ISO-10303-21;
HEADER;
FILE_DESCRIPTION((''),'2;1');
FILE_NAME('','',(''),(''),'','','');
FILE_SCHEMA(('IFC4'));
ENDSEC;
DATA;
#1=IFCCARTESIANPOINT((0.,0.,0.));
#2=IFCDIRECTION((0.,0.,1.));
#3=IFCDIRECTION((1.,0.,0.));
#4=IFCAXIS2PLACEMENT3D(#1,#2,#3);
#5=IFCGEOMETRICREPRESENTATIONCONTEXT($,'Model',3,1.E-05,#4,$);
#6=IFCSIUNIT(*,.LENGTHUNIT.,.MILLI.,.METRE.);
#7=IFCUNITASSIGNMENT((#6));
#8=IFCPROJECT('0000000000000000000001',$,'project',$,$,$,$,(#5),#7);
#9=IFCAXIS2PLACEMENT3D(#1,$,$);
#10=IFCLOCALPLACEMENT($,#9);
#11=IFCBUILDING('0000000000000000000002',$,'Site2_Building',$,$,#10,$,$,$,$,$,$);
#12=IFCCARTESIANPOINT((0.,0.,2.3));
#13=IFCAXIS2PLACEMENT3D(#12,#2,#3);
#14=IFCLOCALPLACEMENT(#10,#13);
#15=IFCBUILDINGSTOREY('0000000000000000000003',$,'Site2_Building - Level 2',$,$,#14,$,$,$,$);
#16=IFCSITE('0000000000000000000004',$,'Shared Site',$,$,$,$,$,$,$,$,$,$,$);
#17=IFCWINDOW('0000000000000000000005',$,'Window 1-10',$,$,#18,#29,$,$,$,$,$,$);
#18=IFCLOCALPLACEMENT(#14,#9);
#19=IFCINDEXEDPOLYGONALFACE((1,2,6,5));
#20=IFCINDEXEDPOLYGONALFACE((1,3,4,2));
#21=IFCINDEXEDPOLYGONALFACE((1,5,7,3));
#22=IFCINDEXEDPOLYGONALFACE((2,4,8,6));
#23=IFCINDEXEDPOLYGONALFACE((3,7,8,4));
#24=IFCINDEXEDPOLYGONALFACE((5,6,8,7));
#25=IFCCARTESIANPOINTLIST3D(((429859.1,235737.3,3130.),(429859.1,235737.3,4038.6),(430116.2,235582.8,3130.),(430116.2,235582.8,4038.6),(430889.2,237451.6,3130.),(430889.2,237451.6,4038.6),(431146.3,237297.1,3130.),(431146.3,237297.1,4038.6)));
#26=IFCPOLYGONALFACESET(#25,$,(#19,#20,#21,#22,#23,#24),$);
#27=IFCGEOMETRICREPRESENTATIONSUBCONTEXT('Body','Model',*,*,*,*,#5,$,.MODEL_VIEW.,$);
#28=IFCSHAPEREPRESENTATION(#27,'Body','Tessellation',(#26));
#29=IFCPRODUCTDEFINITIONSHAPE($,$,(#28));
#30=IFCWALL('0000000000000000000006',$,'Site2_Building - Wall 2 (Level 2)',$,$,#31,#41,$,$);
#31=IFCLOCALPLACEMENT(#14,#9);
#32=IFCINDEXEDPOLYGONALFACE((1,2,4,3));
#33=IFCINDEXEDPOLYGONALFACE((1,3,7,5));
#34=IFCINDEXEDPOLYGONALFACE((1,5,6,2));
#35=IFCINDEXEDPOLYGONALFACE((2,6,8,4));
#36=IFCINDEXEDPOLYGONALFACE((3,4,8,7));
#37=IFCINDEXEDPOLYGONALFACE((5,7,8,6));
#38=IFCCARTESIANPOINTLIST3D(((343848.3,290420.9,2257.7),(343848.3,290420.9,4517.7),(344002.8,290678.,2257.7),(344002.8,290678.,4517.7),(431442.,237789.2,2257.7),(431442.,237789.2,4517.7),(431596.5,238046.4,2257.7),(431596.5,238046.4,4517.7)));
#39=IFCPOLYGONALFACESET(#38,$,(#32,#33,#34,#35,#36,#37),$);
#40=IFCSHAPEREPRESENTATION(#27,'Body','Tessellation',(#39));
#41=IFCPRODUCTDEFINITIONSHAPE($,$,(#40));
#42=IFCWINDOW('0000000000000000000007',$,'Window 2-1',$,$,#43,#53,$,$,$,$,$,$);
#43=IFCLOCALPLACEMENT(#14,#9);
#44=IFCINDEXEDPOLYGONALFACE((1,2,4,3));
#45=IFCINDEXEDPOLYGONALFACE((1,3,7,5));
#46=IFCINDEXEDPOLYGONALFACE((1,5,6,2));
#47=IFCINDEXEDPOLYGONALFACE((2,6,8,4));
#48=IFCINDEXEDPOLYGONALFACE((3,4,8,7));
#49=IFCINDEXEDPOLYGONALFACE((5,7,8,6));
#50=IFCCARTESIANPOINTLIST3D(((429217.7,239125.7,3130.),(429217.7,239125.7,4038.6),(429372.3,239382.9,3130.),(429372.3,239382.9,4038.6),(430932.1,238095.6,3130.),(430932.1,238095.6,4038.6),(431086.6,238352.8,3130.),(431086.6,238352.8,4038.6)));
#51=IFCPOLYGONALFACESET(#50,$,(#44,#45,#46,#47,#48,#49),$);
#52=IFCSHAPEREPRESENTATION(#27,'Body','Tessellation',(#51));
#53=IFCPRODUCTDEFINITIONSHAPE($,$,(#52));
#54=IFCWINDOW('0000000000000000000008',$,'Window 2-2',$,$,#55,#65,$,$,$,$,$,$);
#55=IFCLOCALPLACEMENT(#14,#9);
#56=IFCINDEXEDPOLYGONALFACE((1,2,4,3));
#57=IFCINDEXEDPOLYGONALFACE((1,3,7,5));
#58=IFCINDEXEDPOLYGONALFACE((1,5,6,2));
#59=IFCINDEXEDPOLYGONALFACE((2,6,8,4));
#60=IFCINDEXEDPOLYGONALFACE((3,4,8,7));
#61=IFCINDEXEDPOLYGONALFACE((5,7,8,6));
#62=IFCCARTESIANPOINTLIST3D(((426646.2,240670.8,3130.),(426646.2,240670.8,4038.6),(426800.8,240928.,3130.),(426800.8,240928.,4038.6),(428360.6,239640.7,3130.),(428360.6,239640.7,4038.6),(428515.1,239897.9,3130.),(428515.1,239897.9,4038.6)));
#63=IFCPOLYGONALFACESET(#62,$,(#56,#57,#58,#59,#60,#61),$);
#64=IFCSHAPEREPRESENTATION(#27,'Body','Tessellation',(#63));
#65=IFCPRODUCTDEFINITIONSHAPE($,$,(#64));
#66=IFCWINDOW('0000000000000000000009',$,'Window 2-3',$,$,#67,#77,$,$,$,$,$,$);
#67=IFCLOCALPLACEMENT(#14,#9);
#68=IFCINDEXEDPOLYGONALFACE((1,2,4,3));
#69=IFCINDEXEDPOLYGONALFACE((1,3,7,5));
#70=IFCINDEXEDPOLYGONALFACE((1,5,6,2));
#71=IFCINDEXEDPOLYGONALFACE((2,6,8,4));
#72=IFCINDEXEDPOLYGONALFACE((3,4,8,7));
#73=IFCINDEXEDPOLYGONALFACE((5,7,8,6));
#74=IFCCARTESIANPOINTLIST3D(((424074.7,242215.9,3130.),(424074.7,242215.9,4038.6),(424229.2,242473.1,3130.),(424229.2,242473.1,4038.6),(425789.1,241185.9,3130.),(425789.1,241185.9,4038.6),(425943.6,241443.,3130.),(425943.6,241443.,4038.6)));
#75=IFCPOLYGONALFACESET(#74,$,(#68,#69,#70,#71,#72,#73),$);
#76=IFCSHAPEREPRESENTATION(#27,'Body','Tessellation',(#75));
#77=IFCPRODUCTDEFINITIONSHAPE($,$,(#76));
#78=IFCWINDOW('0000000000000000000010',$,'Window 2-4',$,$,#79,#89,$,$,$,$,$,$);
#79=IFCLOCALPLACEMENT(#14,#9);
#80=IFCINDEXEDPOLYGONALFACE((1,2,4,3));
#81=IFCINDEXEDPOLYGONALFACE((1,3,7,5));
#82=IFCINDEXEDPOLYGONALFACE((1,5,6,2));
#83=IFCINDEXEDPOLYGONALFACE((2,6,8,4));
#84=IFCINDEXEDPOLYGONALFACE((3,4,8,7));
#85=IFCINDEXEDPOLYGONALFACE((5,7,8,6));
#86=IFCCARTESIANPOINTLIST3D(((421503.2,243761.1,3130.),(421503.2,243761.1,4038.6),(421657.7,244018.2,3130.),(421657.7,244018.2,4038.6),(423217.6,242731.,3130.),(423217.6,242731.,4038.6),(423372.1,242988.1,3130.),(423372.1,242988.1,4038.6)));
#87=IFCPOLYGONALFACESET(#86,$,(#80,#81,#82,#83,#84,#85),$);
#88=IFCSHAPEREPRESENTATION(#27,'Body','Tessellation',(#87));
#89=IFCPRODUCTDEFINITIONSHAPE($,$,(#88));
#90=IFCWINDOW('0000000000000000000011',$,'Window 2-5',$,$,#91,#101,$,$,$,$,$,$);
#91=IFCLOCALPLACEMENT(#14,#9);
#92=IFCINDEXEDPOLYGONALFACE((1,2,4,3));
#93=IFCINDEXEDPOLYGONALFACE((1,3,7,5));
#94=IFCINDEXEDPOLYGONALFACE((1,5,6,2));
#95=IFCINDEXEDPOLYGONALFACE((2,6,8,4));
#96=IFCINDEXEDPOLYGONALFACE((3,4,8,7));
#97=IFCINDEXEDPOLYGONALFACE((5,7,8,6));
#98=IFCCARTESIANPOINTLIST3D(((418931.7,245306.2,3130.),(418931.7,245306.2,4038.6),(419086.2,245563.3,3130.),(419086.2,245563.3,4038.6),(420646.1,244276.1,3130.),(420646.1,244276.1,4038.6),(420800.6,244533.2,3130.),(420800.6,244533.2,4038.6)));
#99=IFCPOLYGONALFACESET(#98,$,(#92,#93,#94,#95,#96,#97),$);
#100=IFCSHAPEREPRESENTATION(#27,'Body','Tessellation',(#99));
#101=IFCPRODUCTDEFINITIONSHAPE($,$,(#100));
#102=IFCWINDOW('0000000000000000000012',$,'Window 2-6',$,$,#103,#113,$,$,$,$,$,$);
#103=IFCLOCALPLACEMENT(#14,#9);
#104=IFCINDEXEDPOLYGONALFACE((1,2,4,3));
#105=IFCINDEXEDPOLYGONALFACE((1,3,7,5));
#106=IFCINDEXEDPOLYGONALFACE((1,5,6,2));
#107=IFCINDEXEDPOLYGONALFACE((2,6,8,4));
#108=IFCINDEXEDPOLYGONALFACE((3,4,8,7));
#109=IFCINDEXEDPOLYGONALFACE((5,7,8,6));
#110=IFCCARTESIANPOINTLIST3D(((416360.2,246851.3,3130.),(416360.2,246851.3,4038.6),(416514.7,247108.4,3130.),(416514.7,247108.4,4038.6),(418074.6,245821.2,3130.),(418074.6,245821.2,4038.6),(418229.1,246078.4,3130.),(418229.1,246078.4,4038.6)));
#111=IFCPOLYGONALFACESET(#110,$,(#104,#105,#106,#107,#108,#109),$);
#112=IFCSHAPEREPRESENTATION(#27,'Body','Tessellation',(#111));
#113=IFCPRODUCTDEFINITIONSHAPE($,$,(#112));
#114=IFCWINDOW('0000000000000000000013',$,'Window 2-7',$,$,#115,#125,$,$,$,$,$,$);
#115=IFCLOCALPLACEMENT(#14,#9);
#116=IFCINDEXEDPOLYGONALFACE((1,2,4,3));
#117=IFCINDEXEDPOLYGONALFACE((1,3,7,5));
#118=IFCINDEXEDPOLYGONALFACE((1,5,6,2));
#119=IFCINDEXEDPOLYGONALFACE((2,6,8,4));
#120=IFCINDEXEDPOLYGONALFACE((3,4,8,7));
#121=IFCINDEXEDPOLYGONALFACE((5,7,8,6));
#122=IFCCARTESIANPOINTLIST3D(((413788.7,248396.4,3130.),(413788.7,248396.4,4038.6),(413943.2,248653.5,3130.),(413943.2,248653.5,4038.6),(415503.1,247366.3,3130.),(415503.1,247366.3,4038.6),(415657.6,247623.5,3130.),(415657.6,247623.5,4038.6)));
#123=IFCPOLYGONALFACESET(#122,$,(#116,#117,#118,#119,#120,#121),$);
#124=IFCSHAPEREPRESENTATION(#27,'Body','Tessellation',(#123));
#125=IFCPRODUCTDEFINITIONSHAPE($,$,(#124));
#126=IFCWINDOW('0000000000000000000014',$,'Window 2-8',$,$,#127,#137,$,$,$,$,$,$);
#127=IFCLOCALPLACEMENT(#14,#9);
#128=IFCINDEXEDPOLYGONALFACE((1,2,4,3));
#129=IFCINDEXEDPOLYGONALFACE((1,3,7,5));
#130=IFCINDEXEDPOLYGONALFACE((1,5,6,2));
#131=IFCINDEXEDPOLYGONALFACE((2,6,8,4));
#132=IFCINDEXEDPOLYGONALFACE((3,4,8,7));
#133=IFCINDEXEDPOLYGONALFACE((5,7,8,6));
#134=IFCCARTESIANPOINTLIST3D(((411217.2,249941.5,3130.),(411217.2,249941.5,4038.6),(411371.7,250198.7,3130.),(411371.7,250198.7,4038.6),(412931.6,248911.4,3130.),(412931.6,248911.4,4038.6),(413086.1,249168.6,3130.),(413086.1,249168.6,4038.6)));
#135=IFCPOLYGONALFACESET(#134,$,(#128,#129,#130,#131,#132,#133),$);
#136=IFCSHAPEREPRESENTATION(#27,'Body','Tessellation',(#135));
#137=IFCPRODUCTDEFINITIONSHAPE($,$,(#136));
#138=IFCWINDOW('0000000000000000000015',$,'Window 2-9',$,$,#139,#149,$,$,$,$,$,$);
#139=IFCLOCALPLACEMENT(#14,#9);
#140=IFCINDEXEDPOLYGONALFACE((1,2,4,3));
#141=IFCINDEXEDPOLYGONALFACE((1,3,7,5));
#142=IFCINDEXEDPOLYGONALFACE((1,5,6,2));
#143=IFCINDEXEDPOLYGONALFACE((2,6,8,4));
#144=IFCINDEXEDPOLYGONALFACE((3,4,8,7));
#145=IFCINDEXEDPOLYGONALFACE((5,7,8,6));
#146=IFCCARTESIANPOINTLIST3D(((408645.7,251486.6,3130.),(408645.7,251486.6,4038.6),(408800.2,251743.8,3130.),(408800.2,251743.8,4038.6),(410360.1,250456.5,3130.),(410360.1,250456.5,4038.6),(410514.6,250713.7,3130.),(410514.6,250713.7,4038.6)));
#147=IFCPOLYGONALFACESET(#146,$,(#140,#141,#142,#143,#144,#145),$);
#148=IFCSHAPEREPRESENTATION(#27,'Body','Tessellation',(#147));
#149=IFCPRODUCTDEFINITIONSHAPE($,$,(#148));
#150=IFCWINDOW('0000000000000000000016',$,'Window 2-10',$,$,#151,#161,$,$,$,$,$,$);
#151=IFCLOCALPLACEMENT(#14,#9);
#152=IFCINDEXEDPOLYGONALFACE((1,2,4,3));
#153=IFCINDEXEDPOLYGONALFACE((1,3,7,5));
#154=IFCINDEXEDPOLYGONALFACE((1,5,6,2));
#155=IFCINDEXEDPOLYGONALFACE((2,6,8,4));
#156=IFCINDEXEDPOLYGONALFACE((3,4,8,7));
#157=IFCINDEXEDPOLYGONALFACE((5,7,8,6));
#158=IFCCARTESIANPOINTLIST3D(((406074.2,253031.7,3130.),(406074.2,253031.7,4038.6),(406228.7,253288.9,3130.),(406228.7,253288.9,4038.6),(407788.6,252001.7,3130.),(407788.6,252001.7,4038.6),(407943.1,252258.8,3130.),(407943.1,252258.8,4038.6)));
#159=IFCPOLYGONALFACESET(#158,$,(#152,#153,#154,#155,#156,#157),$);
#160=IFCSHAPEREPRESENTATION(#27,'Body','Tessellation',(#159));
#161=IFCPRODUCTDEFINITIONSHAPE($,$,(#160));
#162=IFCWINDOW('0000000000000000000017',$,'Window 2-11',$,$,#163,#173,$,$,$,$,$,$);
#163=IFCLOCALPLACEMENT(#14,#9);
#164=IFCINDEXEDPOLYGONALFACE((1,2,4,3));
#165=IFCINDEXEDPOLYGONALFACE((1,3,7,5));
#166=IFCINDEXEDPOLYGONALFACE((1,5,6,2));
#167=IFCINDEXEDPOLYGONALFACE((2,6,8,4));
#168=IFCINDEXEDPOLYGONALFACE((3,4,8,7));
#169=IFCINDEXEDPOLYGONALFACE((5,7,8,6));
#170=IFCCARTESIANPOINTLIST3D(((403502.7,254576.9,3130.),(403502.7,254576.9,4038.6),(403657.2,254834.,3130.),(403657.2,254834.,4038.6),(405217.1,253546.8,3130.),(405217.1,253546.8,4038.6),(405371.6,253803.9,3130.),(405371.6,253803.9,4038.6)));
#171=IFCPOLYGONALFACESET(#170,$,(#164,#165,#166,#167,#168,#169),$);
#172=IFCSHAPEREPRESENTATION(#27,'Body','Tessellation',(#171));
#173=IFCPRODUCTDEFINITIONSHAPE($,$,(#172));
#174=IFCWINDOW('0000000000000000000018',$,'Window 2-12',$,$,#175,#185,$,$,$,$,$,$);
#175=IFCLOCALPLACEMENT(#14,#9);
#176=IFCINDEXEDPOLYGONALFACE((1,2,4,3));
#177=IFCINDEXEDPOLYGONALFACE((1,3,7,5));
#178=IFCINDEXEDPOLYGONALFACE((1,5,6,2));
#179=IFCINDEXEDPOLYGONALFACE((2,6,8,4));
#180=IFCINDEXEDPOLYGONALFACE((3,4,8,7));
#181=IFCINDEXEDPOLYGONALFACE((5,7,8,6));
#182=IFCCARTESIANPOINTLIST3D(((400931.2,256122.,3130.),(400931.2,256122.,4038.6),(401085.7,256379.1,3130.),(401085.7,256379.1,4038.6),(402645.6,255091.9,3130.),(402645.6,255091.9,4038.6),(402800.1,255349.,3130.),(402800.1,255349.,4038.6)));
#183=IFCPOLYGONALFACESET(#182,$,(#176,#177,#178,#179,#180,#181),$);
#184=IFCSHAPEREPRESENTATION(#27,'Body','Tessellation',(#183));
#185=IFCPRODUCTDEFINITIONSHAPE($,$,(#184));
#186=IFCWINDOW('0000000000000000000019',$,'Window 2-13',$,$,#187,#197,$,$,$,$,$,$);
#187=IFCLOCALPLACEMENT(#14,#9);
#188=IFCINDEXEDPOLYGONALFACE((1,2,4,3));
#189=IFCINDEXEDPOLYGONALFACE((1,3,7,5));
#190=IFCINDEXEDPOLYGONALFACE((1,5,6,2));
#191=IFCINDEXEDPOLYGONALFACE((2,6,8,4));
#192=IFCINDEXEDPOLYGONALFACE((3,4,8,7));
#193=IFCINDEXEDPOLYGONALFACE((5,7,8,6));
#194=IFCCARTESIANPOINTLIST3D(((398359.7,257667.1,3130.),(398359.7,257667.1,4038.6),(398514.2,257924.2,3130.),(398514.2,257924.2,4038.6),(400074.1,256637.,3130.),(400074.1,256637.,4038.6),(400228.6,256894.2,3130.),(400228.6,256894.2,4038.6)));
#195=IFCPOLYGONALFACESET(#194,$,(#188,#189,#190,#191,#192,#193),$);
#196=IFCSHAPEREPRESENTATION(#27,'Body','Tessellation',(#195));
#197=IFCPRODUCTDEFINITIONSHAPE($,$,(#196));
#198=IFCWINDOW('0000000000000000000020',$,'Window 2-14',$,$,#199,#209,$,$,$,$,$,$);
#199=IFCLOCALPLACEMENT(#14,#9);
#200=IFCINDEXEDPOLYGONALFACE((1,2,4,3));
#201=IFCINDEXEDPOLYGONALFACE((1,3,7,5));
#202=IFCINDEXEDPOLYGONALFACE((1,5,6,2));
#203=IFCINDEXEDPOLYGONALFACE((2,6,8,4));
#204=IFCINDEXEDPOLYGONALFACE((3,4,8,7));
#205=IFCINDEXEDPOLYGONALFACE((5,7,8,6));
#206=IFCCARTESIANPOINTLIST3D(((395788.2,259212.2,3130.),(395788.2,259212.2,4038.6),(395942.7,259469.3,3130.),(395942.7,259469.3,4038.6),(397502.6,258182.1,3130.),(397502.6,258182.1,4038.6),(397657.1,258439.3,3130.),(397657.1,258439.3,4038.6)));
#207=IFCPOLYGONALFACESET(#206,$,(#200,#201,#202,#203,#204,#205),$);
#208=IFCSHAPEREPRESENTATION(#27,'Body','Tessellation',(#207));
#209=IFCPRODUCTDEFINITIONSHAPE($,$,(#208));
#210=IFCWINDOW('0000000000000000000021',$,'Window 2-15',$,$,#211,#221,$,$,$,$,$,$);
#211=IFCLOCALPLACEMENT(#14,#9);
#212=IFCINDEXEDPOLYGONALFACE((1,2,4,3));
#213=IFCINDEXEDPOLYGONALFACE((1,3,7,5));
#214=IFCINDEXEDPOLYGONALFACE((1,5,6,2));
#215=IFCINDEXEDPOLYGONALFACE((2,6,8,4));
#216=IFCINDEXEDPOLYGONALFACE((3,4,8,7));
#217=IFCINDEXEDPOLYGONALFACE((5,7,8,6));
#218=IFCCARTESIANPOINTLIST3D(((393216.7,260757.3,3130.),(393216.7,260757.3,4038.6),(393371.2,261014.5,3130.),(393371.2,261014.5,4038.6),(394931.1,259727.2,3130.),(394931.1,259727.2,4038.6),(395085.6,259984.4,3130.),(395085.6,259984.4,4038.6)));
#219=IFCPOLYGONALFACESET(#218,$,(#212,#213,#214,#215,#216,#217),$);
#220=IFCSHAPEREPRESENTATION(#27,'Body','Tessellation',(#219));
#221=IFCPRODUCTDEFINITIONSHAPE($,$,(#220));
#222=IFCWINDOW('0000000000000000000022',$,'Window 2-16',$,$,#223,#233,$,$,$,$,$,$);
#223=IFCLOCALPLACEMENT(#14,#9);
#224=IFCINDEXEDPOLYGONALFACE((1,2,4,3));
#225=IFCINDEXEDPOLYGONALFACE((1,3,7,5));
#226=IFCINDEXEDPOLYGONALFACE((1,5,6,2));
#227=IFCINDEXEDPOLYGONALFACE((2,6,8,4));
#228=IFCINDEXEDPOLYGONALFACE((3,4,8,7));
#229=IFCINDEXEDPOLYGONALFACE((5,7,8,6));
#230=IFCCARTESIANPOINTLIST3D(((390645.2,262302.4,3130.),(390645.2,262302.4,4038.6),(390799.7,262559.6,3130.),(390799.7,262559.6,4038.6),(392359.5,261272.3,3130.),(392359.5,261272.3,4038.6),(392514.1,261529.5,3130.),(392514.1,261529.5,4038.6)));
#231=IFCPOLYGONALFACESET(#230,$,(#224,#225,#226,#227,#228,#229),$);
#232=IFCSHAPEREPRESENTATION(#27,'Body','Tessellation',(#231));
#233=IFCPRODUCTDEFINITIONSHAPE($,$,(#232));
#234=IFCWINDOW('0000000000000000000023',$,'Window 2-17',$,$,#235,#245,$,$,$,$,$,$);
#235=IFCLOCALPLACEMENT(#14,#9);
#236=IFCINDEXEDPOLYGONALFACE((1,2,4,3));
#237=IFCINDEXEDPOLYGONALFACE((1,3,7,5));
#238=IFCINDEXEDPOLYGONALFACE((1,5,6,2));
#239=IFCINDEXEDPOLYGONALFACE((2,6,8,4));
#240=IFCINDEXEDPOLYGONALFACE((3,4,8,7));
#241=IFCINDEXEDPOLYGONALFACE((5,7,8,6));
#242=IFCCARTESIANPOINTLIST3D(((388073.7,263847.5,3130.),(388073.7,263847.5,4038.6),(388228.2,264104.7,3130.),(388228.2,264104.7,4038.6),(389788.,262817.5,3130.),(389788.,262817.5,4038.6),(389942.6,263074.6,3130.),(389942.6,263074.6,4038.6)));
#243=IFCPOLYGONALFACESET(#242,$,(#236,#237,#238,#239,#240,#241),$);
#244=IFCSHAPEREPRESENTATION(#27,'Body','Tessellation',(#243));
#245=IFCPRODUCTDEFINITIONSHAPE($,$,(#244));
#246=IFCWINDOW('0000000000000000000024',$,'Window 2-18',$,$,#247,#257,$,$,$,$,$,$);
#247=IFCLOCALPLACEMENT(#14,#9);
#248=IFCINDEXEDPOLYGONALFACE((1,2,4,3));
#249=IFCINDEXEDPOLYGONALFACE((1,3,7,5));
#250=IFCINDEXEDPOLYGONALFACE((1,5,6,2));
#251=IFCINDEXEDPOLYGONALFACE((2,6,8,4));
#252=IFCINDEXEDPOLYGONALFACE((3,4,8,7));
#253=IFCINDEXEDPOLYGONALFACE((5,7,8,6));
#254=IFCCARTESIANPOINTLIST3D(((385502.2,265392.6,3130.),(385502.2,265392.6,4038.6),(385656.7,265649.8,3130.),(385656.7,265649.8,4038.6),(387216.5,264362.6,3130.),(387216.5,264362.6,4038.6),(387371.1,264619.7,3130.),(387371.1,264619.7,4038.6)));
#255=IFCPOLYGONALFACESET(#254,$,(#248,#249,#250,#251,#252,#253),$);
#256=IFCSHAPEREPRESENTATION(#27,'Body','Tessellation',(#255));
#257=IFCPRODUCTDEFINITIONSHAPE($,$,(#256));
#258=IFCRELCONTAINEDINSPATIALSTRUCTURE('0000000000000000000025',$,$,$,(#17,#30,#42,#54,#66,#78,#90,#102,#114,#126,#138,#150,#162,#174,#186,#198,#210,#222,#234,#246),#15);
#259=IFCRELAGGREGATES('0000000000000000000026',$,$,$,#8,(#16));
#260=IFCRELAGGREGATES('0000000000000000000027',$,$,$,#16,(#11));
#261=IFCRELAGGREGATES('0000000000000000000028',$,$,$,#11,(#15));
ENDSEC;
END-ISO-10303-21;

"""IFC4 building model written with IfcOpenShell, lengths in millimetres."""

from ifc_helpers import new_model, si_unit, frame, origin, origin_with_axes, place, context, subcontext, project, spatial, indexed_curve, outline, extrude, element, save


model = new_model("IFC4")

# Units and contexts
model_context = context("Model", 3, precision=1e-05, world=origin_with_axes())
body_context = subcontext(model_context, "Body", "Model", "MODEL_VIEW")
ifc_project = project(units=[si_unit("LENGTHUNIT", "METRE", prefix="MILLI")], contexts=[model_context])

# Site, building, storey
site = spatial("IfcSite", under=ifc_project, Name="Shared Site")
building_placement = place(None, origin())
building = spatial("IfcBuilding", under=site, at=building_placement, Name="Site2_Building")
storey_placement = place(building_placement, frame((0.0, 0.0, 2.3), z_axis=(0.0, 0.0, 1.0), x_axis=(1.0, 0.0, 0.0)))
storey = spatial("IfcBuildingStorey", under=building, at=storey_placement, Name="Site2_Building - Level 2")

# Window
window_placement = place(storey_placement, frame((430116.2, 235582.8, 3130.0), z_axis=(0.0, 0.0, 1.0), x_axis=(0.515038, 0.857167, 0.0)))
element("IfcWindow", 1, at=window_placement, inside=storey, Name="Window 1-10", context=body_context, shape_type="SweptSolid", body=[
    extrude(outline(indexed_curve([(0.0, 0.0), (0.0, 300.0), (2000.0, 300.0), (2000.0, 0.0), (0.0, 0.0)], self_intersect=False)), origin_with_axes(), (0.0, 0.0, 1.0), 908.6),
])

# Wall
wall_placement = place(storey_placement, frame((431596.5, 238046.4, 2257.7), z_axis=(0.0, 0.0, 1.0), x_axis=(-0.857167, 0.515038, 0.0)))
element("IfcWall", 2, at=wall_placement, inside=storey, Name="Site2_Building - Wall 2 (Level 2)", context=body_context, shape_type="SweptSolid", body=[
    extrude(outline(indexed_curve([(0.0, 0.0), (0.0, 300.0), (102189.8, 300.0), (102189.8, 0.0), (0.0, 0.0)], self_intersect=False)), origin_with_axes(), (0.0, 0.0, 1.0), 2260.0),
])

# Windows
for number, where, z_axis, x_axis, name in (
    (3, (431086.6, 238352.8, 3130.0), (0.0, 0.0, 1.0), (-0.857167, 0.515038, 0.0), "Window 2-1"),
    (4, (428515.1, 239897.9, 3130.0), (0.0, 0.0, 1.0), (-0.857167, 0.515038, 0.0), "Window 2-2"),
    (5, (425943.6, 241443.0, 3130.0), (0.0, 0.0, 1.0), (-0.857167, 0.515038, 0.0), "Window 2-3"),
    (6, (423372.1, 242988.1, 3130.0), (0.0, 0.0, 1.0), (-0.857167, 0.515038, 0.0), "Window 2-4"),
    (7, (420800.6, 244533.2, 3130.0), (0.0, 0.0, 1.0), (-0.857167, 0.515038, 0.0), "Window 2-5"),
    (8, (418229.1, 246078.4, 3130.0), (0.0, 0.0, 1.0), (-0.857167, 0.515038, 0.0), "Window 2-6"),
    (9, (415657.6, 247623.5, 3130.0), (0.0, 0.0, 1.0), (-0.857167, 0.515038, 0.0), "Window 2-7"),
    (10, (413086.1, 249168.6, 3130.0), (0.0, 0.0, 1.0), (-0.857167, 0.515038, 0.0), "Window 2-8"),
    (11, (410514.6, 250713.7, 3130.0), (0.0, 0.0, 1.0), (-0.857167, 0.515038, 0.0), "Window 2-9"),
    (12, (407943.1, 252258.8, 3130.0), (0.0, 0.0, 1.0), (-0.857167, 0.515038, 0.0), "Window 2-10"),
    (13, (405371.6, 253803.9, 3130.0), (0.0, 0.0, 1.0), (-0.857167, 0.515038, 0.0), "Window 2-11"),
    (14, (402800.1, 255349.0, 3130.0), (0.0, 0.0, 1.0), (-0.857167, 0.515038, 0.0), "Window 2-12"),
    (15, (400228.6, 256894.2, 3130.0), (0.0, 0.0, 1.0), (-0.857167, 0.515038, 0.0), "Window 2-13"),
    (16, (397657.1, 258439.3, 3130.0), (0.0, 0.0, 1.0), (-0.857167, 0.515038, 0.0), "Window 2-14"),
    (17, (395085.6, 259984.4, 3130.0), (0.0, 0.0, 1.0), (-0.857167, 0.515038, 0.0), "Window 2-15"),
    (18, (392514.1, 261529.5, 3130.0), (0.0, 0.0, 1.0), (-0.857167, 0.515038, 0.0), "Window 2-16"),
    (19, (389942.6, 263074.6, 3130.0), (0.0, 0.0, 1.0), (-0.857167, 0.515038, 0.0), "Window 2-17"),
    (20, (387371.1, 264619.7, 3130.0), (0.0, 0.0, 1.0), (-0.857167, 0.515038, 0.0), "Window 2-18"),
):
    element("IfcWindow", number, at=place(storey_placement, frame(where, z_axis=z_axis, x_axis=x_axis)), inside=storey, Name=name, context=body_context, shape_type="SweptSolid", body=[
        extrude(outline(indexed_curve([(0.0, 0.0), (0.0, 300.0), (2000.0, 300.0), (2000.0, 0.0), (0.0, 0.0)], self_intersect=False)), origin_with_axes(), (0.0, 0.0, 1.0), 908.6),
    ])

save(model, "model.ifc")
